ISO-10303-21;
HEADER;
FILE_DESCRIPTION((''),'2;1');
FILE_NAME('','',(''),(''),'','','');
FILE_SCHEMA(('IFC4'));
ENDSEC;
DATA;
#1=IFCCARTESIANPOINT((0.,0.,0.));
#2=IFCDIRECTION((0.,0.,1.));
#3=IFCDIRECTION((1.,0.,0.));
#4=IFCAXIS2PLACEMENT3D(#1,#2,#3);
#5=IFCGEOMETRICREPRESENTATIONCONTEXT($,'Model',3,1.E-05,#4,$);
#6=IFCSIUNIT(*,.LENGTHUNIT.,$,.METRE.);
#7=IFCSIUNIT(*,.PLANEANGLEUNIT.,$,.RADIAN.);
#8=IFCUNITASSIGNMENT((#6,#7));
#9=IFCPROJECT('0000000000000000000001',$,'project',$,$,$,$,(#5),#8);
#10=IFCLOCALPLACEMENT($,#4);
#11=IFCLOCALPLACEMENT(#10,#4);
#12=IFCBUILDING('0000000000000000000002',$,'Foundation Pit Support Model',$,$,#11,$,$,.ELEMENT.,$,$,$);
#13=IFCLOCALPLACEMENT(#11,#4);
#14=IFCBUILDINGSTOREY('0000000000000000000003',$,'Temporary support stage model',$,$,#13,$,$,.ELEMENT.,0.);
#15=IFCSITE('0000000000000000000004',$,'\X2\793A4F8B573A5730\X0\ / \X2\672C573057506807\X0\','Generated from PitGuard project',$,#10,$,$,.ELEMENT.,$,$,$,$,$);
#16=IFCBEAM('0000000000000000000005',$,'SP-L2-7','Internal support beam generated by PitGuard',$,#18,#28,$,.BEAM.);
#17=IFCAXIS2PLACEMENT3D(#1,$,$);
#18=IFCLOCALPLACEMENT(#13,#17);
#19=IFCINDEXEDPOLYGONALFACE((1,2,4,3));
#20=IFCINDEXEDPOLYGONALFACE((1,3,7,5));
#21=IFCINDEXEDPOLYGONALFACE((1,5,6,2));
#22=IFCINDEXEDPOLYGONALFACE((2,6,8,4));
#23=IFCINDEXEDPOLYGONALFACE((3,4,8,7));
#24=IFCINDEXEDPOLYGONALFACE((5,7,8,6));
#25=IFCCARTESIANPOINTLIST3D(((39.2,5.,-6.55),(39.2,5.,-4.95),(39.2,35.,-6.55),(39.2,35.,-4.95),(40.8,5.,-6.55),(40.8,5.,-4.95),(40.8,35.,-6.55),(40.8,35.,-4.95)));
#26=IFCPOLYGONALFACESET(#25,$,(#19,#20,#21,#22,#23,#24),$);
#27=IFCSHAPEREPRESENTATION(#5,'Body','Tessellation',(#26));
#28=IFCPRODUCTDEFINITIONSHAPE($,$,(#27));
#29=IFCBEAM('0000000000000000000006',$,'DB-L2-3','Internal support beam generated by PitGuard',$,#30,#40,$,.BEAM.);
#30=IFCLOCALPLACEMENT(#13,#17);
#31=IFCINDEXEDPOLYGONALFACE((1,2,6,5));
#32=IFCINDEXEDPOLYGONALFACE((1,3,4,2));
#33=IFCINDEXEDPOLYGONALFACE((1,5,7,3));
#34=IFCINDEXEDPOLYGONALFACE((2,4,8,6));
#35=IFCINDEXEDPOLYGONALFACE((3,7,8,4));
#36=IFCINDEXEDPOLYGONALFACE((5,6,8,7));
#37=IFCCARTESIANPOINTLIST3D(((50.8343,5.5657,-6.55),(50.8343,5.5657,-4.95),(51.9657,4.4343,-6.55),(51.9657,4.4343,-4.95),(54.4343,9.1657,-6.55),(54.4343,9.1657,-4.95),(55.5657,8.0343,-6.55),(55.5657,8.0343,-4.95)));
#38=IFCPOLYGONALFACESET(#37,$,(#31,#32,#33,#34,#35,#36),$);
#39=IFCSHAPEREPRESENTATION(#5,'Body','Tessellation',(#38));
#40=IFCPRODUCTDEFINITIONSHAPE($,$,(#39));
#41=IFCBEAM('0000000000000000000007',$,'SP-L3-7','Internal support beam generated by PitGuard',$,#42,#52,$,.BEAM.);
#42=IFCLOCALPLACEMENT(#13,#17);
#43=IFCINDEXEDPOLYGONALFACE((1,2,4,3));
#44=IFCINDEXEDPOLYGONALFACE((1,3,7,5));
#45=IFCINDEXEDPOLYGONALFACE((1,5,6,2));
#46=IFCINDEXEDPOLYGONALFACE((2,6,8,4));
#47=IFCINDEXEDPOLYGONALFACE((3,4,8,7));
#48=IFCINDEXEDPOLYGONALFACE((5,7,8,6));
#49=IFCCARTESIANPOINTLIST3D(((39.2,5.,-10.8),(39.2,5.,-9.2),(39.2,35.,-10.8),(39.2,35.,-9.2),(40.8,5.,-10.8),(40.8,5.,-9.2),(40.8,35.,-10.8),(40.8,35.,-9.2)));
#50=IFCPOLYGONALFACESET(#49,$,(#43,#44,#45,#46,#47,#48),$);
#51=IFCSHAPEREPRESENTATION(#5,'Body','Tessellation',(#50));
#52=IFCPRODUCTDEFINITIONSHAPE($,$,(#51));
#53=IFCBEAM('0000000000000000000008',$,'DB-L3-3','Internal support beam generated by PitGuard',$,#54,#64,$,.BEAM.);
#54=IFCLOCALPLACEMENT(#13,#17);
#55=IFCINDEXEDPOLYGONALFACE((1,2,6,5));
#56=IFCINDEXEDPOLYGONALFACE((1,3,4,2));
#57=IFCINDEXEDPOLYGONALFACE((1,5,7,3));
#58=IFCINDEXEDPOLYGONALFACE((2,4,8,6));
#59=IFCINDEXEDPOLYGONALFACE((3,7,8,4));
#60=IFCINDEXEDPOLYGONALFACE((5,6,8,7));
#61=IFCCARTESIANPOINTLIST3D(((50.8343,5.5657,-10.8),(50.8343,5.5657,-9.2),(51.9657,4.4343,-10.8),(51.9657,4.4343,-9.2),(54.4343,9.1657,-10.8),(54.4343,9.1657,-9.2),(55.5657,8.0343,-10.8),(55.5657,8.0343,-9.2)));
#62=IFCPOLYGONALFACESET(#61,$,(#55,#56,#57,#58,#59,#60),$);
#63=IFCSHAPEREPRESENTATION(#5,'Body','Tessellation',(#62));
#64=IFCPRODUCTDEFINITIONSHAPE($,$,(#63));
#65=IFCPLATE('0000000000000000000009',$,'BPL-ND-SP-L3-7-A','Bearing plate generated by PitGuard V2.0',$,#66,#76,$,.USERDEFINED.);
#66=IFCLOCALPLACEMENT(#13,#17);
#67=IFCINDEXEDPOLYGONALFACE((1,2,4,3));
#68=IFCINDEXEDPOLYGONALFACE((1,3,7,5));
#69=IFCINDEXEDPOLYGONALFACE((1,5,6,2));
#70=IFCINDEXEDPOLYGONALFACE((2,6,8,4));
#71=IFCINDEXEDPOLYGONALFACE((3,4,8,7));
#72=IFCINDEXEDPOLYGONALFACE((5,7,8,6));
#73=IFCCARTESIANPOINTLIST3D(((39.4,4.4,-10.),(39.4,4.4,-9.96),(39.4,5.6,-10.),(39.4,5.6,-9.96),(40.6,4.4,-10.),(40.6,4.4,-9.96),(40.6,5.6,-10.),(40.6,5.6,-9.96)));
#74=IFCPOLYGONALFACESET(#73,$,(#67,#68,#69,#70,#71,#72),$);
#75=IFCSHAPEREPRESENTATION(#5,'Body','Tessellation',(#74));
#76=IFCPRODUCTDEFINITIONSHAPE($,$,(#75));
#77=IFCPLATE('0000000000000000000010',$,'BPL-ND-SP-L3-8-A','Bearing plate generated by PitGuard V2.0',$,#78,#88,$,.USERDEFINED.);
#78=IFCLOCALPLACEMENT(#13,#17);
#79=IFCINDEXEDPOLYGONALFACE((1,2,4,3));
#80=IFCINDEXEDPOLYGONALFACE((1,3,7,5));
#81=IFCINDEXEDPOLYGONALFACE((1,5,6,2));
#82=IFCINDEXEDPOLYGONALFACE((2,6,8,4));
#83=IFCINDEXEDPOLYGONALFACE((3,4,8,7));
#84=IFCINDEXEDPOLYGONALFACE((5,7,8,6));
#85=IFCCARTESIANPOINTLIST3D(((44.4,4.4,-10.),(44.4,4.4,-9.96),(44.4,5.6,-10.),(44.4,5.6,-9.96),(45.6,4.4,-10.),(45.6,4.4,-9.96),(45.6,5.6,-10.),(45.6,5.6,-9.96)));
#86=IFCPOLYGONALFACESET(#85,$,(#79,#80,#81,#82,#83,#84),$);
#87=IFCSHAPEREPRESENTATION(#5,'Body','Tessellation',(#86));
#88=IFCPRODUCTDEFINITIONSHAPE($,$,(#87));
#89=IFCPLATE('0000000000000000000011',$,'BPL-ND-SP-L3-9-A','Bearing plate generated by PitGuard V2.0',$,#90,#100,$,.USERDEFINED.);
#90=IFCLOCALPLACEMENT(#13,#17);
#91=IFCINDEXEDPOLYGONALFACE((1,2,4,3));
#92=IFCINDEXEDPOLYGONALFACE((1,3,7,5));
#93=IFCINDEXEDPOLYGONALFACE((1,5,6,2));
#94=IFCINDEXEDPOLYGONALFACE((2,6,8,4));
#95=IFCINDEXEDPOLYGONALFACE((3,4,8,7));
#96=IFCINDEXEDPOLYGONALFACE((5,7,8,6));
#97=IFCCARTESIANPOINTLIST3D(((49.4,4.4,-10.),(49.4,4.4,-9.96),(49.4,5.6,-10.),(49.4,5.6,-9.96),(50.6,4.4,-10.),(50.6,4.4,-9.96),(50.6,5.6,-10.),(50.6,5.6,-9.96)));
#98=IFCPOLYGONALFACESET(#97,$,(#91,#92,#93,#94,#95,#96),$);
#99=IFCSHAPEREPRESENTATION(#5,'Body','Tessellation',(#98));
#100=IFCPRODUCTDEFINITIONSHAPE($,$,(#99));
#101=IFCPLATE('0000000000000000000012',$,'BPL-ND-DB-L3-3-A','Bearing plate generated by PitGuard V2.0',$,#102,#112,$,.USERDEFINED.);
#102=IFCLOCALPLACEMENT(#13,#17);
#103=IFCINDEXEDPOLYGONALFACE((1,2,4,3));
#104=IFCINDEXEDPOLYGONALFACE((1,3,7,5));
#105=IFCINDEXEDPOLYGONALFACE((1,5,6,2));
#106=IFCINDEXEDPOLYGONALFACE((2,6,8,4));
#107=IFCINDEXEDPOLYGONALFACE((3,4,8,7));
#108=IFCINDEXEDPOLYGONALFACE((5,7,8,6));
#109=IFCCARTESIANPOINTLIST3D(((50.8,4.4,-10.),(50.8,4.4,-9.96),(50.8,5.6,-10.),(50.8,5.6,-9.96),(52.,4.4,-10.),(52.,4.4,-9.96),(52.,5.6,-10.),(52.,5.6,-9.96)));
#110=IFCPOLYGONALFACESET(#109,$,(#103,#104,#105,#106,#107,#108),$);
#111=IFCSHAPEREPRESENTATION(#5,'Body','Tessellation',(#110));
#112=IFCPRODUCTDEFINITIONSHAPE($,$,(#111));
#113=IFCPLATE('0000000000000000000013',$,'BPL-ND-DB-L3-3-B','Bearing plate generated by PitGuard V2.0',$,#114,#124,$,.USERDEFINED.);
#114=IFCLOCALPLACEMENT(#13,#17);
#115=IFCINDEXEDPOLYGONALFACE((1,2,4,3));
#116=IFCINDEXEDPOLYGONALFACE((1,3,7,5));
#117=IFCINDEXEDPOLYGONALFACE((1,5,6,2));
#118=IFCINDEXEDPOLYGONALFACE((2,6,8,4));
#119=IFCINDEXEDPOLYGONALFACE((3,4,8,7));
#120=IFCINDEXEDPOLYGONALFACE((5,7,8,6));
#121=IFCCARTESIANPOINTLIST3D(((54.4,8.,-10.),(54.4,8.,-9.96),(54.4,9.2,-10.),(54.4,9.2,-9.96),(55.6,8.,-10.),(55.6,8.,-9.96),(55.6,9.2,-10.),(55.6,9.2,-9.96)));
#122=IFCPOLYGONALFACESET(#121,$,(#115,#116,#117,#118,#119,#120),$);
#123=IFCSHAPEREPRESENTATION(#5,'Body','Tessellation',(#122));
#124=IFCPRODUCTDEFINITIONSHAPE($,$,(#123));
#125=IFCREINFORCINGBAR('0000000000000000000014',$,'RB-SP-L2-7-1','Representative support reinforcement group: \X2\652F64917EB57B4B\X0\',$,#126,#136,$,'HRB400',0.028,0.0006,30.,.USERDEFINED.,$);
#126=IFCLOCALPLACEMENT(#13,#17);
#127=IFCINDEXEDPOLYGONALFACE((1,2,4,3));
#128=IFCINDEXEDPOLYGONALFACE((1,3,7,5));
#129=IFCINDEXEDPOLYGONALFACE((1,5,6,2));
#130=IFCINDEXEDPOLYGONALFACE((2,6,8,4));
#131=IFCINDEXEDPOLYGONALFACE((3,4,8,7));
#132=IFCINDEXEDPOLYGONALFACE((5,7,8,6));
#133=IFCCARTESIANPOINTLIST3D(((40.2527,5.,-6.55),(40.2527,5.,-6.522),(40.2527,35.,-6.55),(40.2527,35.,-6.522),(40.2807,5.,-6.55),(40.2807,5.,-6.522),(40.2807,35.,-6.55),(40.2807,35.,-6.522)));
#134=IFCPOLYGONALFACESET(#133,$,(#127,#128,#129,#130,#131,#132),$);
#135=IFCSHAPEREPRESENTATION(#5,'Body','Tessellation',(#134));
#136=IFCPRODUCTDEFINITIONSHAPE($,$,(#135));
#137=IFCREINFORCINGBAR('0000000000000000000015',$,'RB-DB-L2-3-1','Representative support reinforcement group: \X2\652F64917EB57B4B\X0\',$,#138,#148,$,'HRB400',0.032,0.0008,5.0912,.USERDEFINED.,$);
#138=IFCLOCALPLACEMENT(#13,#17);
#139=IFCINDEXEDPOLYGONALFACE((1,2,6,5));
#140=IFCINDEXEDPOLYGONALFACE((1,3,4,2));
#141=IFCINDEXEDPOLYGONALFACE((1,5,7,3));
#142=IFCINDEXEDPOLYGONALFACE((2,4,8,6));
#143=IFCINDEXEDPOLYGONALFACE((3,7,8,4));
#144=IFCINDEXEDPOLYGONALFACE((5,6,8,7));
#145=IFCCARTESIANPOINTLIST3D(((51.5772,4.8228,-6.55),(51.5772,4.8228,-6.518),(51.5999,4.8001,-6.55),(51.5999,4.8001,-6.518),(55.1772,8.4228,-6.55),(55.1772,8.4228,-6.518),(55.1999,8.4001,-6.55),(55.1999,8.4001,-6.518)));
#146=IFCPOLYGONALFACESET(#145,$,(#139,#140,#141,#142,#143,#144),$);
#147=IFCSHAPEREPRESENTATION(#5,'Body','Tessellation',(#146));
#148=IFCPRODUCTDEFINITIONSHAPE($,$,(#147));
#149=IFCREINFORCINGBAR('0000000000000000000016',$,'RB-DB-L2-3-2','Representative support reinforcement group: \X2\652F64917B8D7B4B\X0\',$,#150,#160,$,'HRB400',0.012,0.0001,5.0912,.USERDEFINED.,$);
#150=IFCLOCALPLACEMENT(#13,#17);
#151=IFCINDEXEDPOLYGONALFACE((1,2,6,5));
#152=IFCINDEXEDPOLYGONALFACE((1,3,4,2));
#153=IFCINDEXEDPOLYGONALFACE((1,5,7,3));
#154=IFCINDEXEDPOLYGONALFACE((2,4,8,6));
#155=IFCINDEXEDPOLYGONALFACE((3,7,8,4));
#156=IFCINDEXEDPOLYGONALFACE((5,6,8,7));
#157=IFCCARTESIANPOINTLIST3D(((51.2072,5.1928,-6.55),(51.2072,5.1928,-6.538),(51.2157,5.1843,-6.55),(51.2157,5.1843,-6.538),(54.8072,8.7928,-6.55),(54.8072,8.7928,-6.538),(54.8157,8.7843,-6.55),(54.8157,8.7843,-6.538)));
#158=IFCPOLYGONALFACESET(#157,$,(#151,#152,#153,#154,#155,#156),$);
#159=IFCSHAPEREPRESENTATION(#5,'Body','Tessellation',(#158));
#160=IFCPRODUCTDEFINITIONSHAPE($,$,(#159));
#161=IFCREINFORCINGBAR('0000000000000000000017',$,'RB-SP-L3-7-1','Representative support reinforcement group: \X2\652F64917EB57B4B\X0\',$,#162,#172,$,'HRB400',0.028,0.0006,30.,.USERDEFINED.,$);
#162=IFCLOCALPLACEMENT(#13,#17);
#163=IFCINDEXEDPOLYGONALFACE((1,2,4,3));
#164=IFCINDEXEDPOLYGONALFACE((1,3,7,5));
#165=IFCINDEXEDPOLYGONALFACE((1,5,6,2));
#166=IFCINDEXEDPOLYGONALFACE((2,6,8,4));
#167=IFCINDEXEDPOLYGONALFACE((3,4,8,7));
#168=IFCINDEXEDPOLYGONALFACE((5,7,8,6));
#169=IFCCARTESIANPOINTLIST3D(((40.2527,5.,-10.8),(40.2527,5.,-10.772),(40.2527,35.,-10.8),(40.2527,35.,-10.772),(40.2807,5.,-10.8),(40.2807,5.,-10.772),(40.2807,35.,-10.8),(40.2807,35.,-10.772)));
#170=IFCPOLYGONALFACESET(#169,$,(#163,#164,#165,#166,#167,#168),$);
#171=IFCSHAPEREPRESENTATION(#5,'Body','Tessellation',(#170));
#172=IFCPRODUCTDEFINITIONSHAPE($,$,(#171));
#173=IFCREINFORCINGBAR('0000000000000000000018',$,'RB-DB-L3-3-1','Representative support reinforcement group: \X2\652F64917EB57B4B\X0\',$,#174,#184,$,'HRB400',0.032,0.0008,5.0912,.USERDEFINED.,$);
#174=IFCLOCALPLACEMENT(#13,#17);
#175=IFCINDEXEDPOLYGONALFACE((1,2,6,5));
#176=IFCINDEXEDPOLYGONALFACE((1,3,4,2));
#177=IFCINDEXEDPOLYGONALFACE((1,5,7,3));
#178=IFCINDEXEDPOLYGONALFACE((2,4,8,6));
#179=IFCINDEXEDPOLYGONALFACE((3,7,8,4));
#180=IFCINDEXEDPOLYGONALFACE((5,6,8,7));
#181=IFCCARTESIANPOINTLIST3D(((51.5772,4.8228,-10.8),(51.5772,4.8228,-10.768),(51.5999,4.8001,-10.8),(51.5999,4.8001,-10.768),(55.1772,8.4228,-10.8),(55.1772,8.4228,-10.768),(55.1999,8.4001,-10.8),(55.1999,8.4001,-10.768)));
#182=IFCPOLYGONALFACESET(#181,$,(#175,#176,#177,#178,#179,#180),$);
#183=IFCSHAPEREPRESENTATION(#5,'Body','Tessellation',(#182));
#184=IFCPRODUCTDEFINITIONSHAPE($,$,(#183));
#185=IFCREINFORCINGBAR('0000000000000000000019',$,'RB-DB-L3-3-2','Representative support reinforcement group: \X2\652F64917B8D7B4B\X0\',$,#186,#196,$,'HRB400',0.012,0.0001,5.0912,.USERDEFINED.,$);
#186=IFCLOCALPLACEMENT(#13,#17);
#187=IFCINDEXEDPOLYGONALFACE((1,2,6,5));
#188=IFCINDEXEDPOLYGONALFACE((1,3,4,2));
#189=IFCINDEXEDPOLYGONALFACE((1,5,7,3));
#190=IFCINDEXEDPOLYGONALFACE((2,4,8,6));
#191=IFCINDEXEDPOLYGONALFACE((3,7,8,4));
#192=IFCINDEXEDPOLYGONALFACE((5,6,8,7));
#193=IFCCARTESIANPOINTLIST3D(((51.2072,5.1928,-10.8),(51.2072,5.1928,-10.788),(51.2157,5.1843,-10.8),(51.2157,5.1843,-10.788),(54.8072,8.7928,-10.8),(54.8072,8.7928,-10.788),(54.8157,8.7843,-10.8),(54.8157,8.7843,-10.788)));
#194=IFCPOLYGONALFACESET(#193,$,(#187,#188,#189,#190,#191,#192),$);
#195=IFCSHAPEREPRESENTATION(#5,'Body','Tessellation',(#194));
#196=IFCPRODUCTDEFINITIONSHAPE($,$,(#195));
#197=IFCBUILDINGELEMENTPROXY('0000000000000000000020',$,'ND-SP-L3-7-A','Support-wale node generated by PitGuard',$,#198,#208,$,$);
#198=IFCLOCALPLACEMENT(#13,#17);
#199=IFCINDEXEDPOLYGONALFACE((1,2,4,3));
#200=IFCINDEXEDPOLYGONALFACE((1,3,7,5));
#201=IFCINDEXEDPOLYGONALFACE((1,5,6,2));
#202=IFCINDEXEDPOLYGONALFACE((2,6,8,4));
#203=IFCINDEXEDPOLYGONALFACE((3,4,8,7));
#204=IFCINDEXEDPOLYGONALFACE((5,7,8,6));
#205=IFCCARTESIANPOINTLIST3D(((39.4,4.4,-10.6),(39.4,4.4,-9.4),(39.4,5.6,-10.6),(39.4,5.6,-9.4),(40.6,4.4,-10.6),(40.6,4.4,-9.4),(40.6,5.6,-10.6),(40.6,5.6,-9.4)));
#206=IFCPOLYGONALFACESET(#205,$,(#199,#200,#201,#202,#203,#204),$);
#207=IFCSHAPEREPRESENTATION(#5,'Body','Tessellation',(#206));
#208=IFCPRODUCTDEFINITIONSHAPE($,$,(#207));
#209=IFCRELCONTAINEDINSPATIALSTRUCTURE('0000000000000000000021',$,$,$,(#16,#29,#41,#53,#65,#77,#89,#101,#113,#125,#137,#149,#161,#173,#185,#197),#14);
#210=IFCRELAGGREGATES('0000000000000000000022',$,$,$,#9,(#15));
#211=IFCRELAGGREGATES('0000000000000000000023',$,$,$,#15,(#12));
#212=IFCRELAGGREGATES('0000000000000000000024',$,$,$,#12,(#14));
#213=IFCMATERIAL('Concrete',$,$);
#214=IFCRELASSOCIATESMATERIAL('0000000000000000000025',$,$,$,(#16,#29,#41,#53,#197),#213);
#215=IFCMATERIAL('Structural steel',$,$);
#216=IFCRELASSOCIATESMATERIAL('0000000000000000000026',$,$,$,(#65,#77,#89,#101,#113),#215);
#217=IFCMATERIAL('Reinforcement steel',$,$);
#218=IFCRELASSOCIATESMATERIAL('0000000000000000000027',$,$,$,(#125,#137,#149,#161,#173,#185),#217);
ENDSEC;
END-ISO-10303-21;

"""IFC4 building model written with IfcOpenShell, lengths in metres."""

from ifc_helpers import new_model, si_unit, frame, origin_with_axes, origin_2d, place, context, project, spatial, rectangle, extrude, material, element, save


model = new_model("IFC4")

# Units and contexts
model_context = context("Model", 3, precision=1e-05, world=origin_with_axes())
ifc_project = project(units=[si_unit("LENGTHUNIT", "METRE"), si_unit("PLANEANGLEUNIT", "RADIAN")], contexts=[model_context])

# Site, building, storey
site_placement = place(None, origin_with_axes())
site = spatial("IfcSite", under=ifc_project, at=site_placement, Name="示例场地 / 本地坐标", Description="Generated from PitGuard project", CompositionType="ELEMENT")
building_placement = place(site_placement, origin_with_axes())
building = spatial("IfcBuilding", under=site, at=building_placement, Name="Foundation Pit Support Model", CompositionType="ELEMENT")
storey_placement = place(building_placement, origin_with_axes())
storey = spatial("IfcBuildingStorey", under=building, at=storey_placement, Name="Temporary support stage model", CompositionType="ELEMENT", Elevation=0.0)

# Beams
ifc_material_1 = material(Name="Concrete")
beam_1_placement = place(storey_placement, frame((40.0, 20.0, -6.55), z_axis=(0.0, 0.0, 1.0), x_axis=(0.0, 1.0, 0.0)))
element("IfcBeam", 1, at=beam_1_placement, inside=storey, material=ifc_material_1, Name="SP-L2-7", Description="Internal support beam generated by PitGuard", PredefinedType="BEAM", context=model_context, shape_type="SweptSolid", body=[
    extrude(rectangle(XDim=30.0, YDim=1.6, at=origin_2d()), origin_with_axes(), (0.0, 0.0, 1.0), 1.6),
])
beam_2_placement = place(storey_placement, frame((53.2, 6.8, -6.55), z_axis=(0.0, 0.0, 1.0), x_axis=(0.707107, 0.707107, 0.0)))
element("IfcBeam", 2, at=beam_2_placement, inside=storey, material=ifc_material_1, Name="DB-L2-3", Description="Internal support beam generated by PitGuard", PredefinedType="BEAM", context=model_context, shape_type="SweptSolid", body=[
    extrude(rectangle(XDim=5.0912, YDim=1.6, at=origin_2d()), origin_with_axes(), (0.0, 0.0, 1.0), 1.6),
])
beam_3_placement = place(storey_placement, frame((40.0, 20.0, -10.8), z_axis=(0.0, 0.0, 1.0), x_axis=(0.0, 1.0, 0.0)))
element("IfcBeam", 3, at=beam_3_placement, inside=storey, material=ifc_material_1, Name="SP-L3-7", Description="Internal support beam generated by PitGuard", PredefinedType="BEAM", context=model_context, shape_type="SweptSolid", body=[
    extrude(rectangle(XDim=30.0, YDim=1.6, at=origin_2d()), origin_with_axes(), (0.0, 0.0, 1.0), 1.6),
])
beam_4_placement = place(storey_placement, frame((53.2, 6.8, -10.8), z_axis=(0.0, 0.0, 1.0), x_axis=(0.707107, 0.707107, 0.0)))
element("IfcBeam", 4, at=beam_4_placement, inside=storey, material=ifc_material_1, Name="DB-L3-3", Description="Internal support beam generated by PitGuard", PredefinedType="BEAM", context=model_context, shape_type="SweptSolid", body=[
    extrude(rectangle(XDim=5.0912, YDim=1.6, at=origin_2d()), origin_with_axes(), (0.0, 0.0, 1.0), 1.6),
])

# Plates
ifc_material_2 = material(Name="Structural steel")
for number, where, z_axis, x_axis, name in (
    (5, (40.0, 5.0, -10.0), (0.0, 0.0, 1.0), (1.0, 0.0, 0.0), "BPL-ND-SP-L3-7-A"),
    (6, (45.0, 5.0, -10.0), (0.0, 0.0, 1.0), (1.0, 0.0, 0.0), "BPL-ND-SP-L3-8-A"),
    (7, (50.0, 5.0, -10.0), (0.0, 0.0, 1.0), (1.0, 0.0, 0.0), "BPL-ND-SP-L3-9-A"),
    (8, (51.4, 5.0, -10.0), (0.0, 0.0, 1.0), (1.0, 0.0, 0.0), "BPL-ND-DB-L3-3-A"),
    (9, (55.0, 8.6, -10.0), (0.0, 0.0, 1.0), (1.0, 0.0, 0.0), "BPL-ND-DB-L3-3-B"),
):
    element("IfcPlate", number, at=place(storey_placement, frame(where, z_axis=z_axis, x_axis=x_axis)), inside=storey, material=ifc_material_2, Name=name, Description="Bearing plate generated by PitGuard V2.0", PredefinedType="USERDEFINED", context=model_context, shape_type="SweptSolid", body=[
        extrude(rectangle(XDim=1.2, YDim=1.2, at=origin_2d()), origin_with_axes(), (0.0, 0.0, 1.0), 0.04),
    ])

# Reinforcing bars
ifc_material_3 = material(Name="Reinforcement steel")
reinforcing_bar_1_placement = place(storey_placement, frame((40.2667, 20.0, -6.55), z_axis=(0.0, 0.0, 1.0), x_axis=(0.0, 1.0, 0.0)))
element("IfcReinforcingBar", 10, at=reinforcing_bar_1_placement, inside=storey, material=ifc_material_3, Name="RB-SP-L2-7-1", Description="Representative support reinforcement group: 支撑纵筋", SteelGrade="HRB400", BarLength=30.0, CrossSectionArea=0.0006, NominalDiameter=0.028, PredefinedType="USERDEFINED", context=model_context, shape_type="SweptSolid", body=[
    extrude(rectangle(XDim=30.0, YDim=0.028, at=origin_2d()), origin_with_axes(), (0.0, 0.0, 1.0), 0.028),
])
reinforcing_bar_2_placement = place(storey_placement, frame((53.3886, 6.6114, -6.55), z_axis=(0.0, 0.0, 1.0), x_axis=(0.707107, 0.707107, 0.0)))
element("IfcReinforcingBar", 11, at=reinforcing_bar_2_placement, inside=storey, material=ifc_material_3, Name="RB-DB-L2-3-1", Description="Representative support reinforcement group: 支撑纵筋", SteelGrade="HRB400", BarLength=5.0912, CrossSectionArea=0.0008, NominalDiameter=0.032, PredefinedType="USERDEFINED", context=model_context, shape_type="SweptSolid", body=[
    extrude(rectangle(XDim=5.0912, YDim=0.032, at=origin_2d()), origin_with_axes(), (0.0, 0.0, 1.0), 0.032),
])
reinforcing_bar_3_placement = place(storey_placement, frame((53.0114, 6.9886, -6.55), z_axis=(0.0, 0.0, 1.0), x_axis=(0.707107, 0.707107, 0.0)))
element("IfcReinforcingBar", 12, at=reinforcing_bar_3_placement, inside=storey, material=ifc_material_3, Name="RB-DB-L2-3-2", Description="Representative support reinforcement group: 支撑箍筋", SteelGrade="HRB400", BarLength=5.0912, CrossSectionArea=0.0001, NominalDiameter=0.012, PredefinedType="USERDEFINED", context=model_context, shape_type="SweptSolid", body=[
    extrude(rectangle(XDim=5.0912, YDim=0.012, at=origin_2d()), origin_with_axes(), (0.0, 0.0, 1.0), 0.012),
])
reinforcing_bar_4_placement = place(storey_placement, frame((40.2667, 20.0, -10.8), z_axis=(0.0, 0.0, 1.0), x_axis=(0.0, 1.0, 0.0)))
element("IfcReinforcingBar", 13, at=reinforcing_bar_4_placement, inside=storey, material=ifc_material_3, Name="RB-SP-L3-7-1", Description="Representative support reinforcement group: 支撑纵筋", SteelGrade="HRB400", BarLength=30.0, CrossSectionArea=0.0006, NominalDiameter=0.028, PredefinedType="USERDEFINED", context=model_context, shape_type="SweptSolid", body=[
    extrude(rectangle(XDim=30.0, YDim=0.028, at=origin_2d()), origin_with_axes(), (0.0, 0.0, 1.0), 0.028),
])
reinforcing_bar_5_placement = place(storey_placement, frame((53.3886, 6.6114, -10.8), z_axis=(0.0, 0.0, 1.0), x_axis=(0.707107, 0.707107, 0.0)))
element("IfcReinforcingBar", 14, at=reinforcing_bar_5_placement, inside=storey, material=ifc_material_3, Name="RB-DB-L3-3-1", Description="Representative support reinforcement group: 支撑纵筋", SteelGrade="HRB400", BarLength=5.0912, CrossSectionArea=0.0008, NominalDiameter=0.032, PredefinedType="USERDEFINED", context=model_context, shape_type="SweptSolid", body=[
    extrude(rectangle(XDim=5.0912, YDim=0.032, at=origin_2d()), origin_with_axes(), (0.0, 0.0, 1.0), 0.032),
])
reinforcing_bar_6_placement = place(storey_placement, frame((53.0114, 6.9886, -10.8), z_axis=(0.0, 0.0, 1.0), x_axis=(0.707107, 0.707107, 0.0)))
element("IfcReinforcingBar", 15, at=reinforcing_bar_6_placement, inside=storey, material=ifc_material_3, Name="RB-DB-L3-3-2", Description="Representative support reinforcement group: 支撑箍筋", SteelGrade="HRB400", BarLength=5.0912, CrossSectionArea=0.0001, NominalDiameter=0.012, PredefinedType="USERDEFINED", context=model_context, shape_type="SweptSolid", body=[
    extrude(rectangle(XDim=5.0912, YDim=0.012, at=origin_2d()), origin_with_axes(), (0.0, 0.0, 1.0), 0.012),
])

# Building element proxy
proxy_1_placement = place(storey_placement, frame((40.0, 5.0, -10.6), z_axis=(0.0, 0.0, 1.0), x_axis=(1.0, 0.0, 0.0)))
element("IfcBuildingElementProxy", 16, at=proxy_1_placement, inside=storey, material=ifc_material_1, Name="ND-SP-L3-7-A", Description="Support-wale node generated by PitGuard", context=model_context, shape_type="SweptSolid", body=[
    extrude(rectangle(XDim=1.2, YDim=1.2, at=origin_2d()), origin_with_axes(), (0.0, 0.0, 1.0), 1.2),
])

save(model, "model.ifc")
